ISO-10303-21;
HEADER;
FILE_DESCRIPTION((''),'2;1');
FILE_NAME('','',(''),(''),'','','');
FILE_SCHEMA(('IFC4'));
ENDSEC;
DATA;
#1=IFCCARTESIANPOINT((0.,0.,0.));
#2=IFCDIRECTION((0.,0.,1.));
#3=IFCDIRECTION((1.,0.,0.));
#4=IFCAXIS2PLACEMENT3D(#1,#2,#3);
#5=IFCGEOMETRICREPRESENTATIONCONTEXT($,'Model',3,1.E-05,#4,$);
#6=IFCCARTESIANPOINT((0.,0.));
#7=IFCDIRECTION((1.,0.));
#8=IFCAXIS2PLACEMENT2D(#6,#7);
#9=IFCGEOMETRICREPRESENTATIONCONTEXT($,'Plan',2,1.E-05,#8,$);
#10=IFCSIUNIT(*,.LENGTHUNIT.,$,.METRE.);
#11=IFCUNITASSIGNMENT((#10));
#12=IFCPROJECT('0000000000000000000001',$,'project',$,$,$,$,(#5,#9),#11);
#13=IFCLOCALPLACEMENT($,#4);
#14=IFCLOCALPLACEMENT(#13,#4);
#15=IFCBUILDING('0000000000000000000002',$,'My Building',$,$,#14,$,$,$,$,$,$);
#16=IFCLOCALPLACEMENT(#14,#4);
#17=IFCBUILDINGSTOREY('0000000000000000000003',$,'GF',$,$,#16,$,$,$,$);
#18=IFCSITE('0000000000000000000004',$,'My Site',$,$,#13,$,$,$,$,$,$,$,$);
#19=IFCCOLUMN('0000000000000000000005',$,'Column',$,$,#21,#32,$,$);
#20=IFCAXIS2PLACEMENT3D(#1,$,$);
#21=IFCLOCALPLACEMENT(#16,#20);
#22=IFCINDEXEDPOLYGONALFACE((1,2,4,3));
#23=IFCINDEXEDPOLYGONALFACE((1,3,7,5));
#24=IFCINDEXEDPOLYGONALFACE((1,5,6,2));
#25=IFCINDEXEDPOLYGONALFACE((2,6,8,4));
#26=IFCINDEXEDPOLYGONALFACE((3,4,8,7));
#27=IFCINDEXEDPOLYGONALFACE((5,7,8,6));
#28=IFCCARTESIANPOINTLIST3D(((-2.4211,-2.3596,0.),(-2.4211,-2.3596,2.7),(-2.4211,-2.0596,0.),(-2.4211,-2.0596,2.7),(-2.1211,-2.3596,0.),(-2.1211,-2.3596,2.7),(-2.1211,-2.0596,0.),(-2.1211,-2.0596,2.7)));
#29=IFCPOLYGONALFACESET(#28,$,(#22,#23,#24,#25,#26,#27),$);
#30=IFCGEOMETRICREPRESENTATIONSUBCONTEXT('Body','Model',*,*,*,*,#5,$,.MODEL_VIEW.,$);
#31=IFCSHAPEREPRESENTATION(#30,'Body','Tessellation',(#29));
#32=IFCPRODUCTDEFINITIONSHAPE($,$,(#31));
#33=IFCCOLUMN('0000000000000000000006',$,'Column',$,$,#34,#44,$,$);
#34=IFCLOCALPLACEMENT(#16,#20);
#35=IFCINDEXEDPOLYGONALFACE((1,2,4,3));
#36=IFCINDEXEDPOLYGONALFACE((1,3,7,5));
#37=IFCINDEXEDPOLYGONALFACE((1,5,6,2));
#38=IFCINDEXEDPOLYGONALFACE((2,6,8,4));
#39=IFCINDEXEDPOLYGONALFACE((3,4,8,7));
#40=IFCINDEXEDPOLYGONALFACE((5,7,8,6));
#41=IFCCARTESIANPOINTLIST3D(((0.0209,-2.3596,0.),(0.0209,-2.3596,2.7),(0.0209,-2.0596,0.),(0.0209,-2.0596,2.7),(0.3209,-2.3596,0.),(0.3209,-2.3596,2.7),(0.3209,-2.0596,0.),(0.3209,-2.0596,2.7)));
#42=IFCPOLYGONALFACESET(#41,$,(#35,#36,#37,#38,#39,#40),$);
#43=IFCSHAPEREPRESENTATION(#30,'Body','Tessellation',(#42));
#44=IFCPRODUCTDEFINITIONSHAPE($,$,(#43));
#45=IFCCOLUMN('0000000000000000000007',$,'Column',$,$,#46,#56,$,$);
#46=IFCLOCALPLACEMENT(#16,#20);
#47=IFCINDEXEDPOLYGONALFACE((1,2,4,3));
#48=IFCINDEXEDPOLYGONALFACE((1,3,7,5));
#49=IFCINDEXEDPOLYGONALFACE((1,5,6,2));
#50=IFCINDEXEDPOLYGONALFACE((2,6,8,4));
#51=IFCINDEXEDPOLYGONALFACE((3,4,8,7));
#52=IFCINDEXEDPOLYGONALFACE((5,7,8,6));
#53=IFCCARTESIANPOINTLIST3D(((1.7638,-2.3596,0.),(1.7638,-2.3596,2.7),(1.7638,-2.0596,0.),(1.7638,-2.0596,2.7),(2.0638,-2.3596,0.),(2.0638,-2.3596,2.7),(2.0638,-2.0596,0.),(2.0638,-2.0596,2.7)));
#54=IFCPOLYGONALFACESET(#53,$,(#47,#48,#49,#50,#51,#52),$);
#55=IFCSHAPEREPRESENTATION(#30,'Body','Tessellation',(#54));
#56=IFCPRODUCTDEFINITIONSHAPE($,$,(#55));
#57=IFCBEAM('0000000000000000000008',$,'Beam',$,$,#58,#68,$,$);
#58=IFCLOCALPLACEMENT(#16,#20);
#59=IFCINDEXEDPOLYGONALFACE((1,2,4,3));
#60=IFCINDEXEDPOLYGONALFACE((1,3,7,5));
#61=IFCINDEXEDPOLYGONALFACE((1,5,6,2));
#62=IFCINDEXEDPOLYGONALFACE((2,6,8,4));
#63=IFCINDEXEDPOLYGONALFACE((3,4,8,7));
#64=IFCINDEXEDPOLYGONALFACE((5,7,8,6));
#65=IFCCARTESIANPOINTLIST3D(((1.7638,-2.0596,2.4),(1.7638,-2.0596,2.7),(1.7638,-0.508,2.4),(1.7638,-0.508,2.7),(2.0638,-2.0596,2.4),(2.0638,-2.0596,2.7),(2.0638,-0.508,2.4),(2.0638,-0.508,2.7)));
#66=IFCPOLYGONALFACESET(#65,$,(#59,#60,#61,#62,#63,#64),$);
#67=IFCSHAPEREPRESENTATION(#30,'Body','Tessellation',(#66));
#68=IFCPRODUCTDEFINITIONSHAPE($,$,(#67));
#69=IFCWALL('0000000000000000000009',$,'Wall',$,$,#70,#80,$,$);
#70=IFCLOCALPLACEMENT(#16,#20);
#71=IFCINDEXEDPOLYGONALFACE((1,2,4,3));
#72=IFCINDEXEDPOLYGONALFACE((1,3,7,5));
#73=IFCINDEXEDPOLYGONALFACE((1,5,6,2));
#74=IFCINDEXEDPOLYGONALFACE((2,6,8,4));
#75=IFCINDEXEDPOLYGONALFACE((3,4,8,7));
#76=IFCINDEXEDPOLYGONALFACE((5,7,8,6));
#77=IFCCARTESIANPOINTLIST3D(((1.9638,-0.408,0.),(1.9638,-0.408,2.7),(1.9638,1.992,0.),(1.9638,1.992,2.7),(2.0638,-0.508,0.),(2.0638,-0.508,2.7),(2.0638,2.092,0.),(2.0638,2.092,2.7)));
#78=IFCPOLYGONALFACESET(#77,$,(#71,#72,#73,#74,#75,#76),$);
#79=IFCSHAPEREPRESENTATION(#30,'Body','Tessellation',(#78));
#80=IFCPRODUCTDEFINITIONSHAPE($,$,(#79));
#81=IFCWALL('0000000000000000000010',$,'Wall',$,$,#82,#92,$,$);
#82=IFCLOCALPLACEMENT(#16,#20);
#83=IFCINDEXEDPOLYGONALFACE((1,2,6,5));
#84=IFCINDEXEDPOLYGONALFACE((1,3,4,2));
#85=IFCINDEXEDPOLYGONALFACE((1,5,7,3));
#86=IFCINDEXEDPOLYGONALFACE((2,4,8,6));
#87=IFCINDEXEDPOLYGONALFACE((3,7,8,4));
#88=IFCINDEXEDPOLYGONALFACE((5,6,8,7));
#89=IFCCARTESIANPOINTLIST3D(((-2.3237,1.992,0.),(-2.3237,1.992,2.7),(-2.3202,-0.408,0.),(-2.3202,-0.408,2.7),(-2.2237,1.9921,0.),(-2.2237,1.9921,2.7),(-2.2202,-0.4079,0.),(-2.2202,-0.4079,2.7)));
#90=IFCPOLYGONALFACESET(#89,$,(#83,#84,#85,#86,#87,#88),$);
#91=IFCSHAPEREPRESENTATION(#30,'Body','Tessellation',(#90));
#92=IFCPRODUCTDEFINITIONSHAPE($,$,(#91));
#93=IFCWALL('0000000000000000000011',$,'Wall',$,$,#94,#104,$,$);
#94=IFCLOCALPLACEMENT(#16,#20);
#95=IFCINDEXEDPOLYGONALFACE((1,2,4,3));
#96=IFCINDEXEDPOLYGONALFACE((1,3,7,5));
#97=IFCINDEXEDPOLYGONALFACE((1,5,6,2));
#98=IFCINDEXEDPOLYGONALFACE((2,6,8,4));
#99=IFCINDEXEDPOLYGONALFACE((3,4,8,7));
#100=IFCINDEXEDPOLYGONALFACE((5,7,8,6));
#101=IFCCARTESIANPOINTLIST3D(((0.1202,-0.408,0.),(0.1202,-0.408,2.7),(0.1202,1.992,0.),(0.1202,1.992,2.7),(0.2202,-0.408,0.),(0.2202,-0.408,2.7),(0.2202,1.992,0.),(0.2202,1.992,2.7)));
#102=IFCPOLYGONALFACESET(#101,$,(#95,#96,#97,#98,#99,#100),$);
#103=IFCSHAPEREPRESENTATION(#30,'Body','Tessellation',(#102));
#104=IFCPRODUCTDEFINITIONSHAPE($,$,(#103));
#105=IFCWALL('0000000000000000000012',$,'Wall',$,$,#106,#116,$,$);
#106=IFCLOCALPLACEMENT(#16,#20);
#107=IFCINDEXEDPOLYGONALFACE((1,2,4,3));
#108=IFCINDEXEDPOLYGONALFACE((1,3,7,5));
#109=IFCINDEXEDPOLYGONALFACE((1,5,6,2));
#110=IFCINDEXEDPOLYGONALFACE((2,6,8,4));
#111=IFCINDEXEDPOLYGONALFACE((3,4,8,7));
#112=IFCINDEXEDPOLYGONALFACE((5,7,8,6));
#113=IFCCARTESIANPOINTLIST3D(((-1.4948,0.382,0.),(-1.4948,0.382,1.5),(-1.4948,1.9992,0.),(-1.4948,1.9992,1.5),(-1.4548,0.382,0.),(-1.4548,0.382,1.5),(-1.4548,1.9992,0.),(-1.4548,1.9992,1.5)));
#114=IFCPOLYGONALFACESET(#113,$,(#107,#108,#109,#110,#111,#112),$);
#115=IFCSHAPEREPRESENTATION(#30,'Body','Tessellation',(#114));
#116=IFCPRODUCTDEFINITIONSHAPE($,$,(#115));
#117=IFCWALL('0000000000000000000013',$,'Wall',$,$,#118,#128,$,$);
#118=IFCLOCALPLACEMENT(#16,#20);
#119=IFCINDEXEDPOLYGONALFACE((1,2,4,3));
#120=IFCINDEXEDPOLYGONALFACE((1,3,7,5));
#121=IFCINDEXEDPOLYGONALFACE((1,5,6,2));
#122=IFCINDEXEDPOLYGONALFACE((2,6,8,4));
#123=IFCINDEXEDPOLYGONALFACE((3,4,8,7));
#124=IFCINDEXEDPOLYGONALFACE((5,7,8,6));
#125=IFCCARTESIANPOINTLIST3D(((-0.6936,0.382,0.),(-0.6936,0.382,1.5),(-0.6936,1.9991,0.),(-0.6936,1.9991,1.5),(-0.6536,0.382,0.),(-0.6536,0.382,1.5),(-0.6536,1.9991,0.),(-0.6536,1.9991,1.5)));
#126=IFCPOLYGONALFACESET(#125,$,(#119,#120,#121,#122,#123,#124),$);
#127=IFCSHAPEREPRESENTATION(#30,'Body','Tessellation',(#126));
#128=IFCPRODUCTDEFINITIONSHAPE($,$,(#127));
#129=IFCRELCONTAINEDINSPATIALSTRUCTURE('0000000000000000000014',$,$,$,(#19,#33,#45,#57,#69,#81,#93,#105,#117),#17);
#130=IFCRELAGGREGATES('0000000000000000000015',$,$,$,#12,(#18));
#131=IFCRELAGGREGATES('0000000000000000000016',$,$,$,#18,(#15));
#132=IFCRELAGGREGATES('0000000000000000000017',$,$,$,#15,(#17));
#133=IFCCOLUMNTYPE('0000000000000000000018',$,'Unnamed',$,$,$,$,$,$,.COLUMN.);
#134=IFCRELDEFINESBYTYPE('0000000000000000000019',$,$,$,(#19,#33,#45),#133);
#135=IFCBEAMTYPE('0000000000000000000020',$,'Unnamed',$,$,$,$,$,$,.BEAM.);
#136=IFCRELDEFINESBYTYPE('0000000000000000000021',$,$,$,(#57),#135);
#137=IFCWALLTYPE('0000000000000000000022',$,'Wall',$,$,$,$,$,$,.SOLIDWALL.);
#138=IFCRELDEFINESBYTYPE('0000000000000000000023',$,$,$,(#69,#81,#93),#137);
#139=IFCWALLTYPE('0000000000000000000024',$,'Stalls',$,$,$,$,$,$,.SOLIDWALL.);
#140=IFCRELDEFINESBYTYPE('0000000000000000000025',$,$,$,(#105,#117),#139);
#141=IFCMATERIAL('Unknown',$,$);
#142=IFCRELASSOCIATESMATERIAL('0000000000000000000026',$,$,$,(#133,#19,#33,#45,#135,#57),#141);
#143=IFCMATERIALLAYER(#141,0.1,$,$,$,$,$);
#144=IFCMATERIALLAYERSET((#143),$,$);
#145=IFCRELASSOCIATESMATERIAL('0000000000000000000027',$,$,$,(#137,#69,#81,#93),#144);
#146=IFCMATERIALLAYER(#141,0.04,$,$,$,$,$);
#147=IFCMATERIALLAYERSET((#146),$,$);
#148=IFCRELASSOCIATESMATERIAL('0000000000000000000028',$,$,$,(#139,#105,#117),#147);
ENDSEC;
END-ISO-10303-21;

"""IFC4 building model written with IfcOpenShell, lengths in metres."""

from ifc_helpers import new_model, si_unit, frame, origin_with_axes, origin_2d_with_axis, place, context, subcontext, project, spatial, line, indexed_curve, rectangle, outline, extrude, material, layer, layer_set, layer_usage, material_profile, profile_set, profile_usage, type_object, element, save


model = new_model("IFC4")

# Units and contexts
model_context = context("Model", 3, precision=1e-05, world=origin_with_axes())
plan_context = context("Plan", 2, precision=1e-05, world=origin_2d_with_axis())
body_context_1 = subcontext(model_context, "Body", "Model", "MODEL_VIEW")
ifc_project = project(units=[si_unit("LENGTHUNIT", "METRE")], contexts=[model_context, plan_context])

# Site, building, storey
site_placement = place(None, origin_with_axes())
site = spatial("IfcSite", under=ifc_project, at=site_placement, Name="My Site")
building_placement = place(site_placement, origin_with_axes())
building = spatial("IfcBuilding", under=site, at=building_placement, Name="My Building")
storey_placement = place(building_placement, origin_with_axes())
storey = spatial("IfcBuildingStorey", under=building, at=storey_placement, Name="GF")

# Columns
ifc_material = material(Name="Unknown")
ifc_material_profile_1 = material_profile(ifc_material, rectangle(XDim=0.3, YDim=0.3))
ifc_profile_set_1 = profile_set([ifc_material_profile_1])
ifc_profile_usage_1 = profile_usage(ifc_profile_set_1, cardinal=5)
column_type = type_object("IfcColumnType", Name="Unnamed", PredefinedType="COLUMN", material=ifc_profile_set_1)
column_1_placement = place(storey_placement, frame((-2.2711, -2.2096, 0.0), z_axis=(0.0, 0.0, 1.0), x_axis=(1.0, 0.0, 0.0)))
element("IfcColumn", 1, at=column_1_placement, inside=storey, type_object=column_type, material=ifc_profile_usage_1, Name="Column", context=body_context_1, shape_type="SweptSolid", body=[
    extrude(rectangle(XDim=0.3, YDim=0.3), origin_with_axes(), (0.0, 0.0, 1.0), 2.7),
])
ifc_profile_usage_2 = profile_usage(ifc_profile_set_1, cardinal=5)
column_2_placement = place(storey_placement, frame((0.1709, -2.2096, 0.0), z_axis=(0.0, 0.0, 1.0), x_axis=(1.0, 0.0, 0.0)))
element("IfcColumn", 2, at=column_2_placement, inside=storey, type_object=column_type, material=ifc_profile_usage_2, Name="Column", context=body_context_1, shape_type="SweptSolid", body=[
    extrude(rectangle(XDim=0.3, YDim=0.3), origin_with_axes(), (0.0, 0.0, 1.0), 2.7),
])
ifc_profile_usage_3 = profile_usage(ifc_profile_set_1, cardinal=4)
column_3_placement = place(storey_placement, frame((2.0638, -2.2096, 0.0), z_axis=(0.0, 0.0, 1.0), x_axis=(1.0, 0.0, 0.0)))
element("IfcColumn", 3, at=column_3_placement, inside=storey, type_object=column_type, material=ifc_profile_usage_3, Name="Column", context=body_context_1, shape_type="SweptSolid", body=[
    extrude(rectangle(XDim=0.3, YDim=0.3), frame((-0.15, 0.0, 0.0), z_axis=(0.0, 0.0, 1.0), x_axis=(1.0, 0.0, 0.0)), (0.0, 0.0, 1.0), 2.7),
])

# Beam
ifc_material_profile_2 = material_profile(ifc_material, rectangle(XDim=0.3, YDim=0.3))
ifc_profile_set_2 = profile_set([ifc_material_profile_2])
ifc_profile_usage_4 = profile_usage(ifc_profile_set_2, cardinal=7)
beam_type = type_object("IfcBeamType", Name="Unnamed", PredefinedType="BEAM", material=ifc_profile_set_2)
beam_placement = place(storey_placement, frame((2.0638, -0.508, 2.7), z_axis=(0.0, -1.0, 0.0), x_axis=(1.0, 0.0, 0.0)))
element("IfcBeam", 4, at=beam_placement, inside=storey, type_object=beam_type, material=ifc_profile_usage_4, Name="Beam", context=body_context_1, shape_type="SweptSolid", body=[
    extrude(rectangle(XDim=0.3, YDim=0.3), frame((-0.15, -0.15, 0.0), z_axis=(0.0, 0.0, 1.0), x_axis=(1.0, 0.0, 0.0)), (0.0, 0.0, 1.0), 1.5515),
])

# Wall
ifc_layer_1 = layer(ifc_material, 0.1)
ifc_layer_set_1 = layer_set([ifc_layer_1])
ifc_layer_usage_1 = layer_usage(ifc_layer_set_1, "AXIS2", "POSITIVE", 0.0)
wall_type_1 = type_object("IfcWallType", Name="Wall", PredefinedType="SOLIDWALL", material=ifc_layer_set_1)
wall_1_placement = place(storey_placement, frame((2.0638, -0.508, 0.0), z_axis=(0.0, 0.0, 1.0), x_axis=(0.0, 1.0, 0.0)))
element("IfcWall", 5, at=wall_1_placement, inside=storey, type_object=wall_type_1, material=ifc_layer_usage_1, Name="Wall", context=body_context_1, shape_type="SweptSolid", body=[
    extrude(outline(indexed_curve([(0.0, 0.0), (0.1, 0.1), (2.5, 0.1), (2.6, 0.0)], segments=[line(1, 2, 3, 4, 1)])), origin_with_axes(), (0.0, 0.0, 1.0), 2.7),
])

# Walls
ifc_layer_usage_2 = layer_usage(ifc_layer_set_1, "AXIS2", "POSITIVE", 0.0)
wall_2_placement = place(storey_placement, frame((-2.3237, 1.992, 0.0), z_axis=(0.0, 0.0, 1.0), x_axis=(0.001482, -0.999999, 0.0)))
element("IfcWall", 6, at=wall_2_placement, inside=storey, type_object=wall_type_1, material=ifc_layer_usage_2, Name="Wall", context=body_context_1, shape_type="SweptSolid", body=[
    extrude(outline(indexed_curve([(0.0, 0.0), (0.0, 0.1), (2.4, 0.1), (2.4, 0.0)], segments=[line(1, 2, 3, 4, 1)])), origin_with_axes(), (0.0, 0.0, 1.0), 2.7),
])
ifc_layer_usage_3 = layer_usage(ifc_layer_set_1, "AXIS2", "POSITIVE", 0.0)
wall_3_placement = place(storey_placement, frame((0.1202, 1.992, 0.0), z_axis=(0.0, 0.0, 1.0), x_axis=(0.0, -1.0, 0.0)))
element("IfcWall", 7, at=wall_3_placement, inside=storey, type_object=wall_type_1, material=ifc_layer_usage_3, Name="Wall", context=body_context_1, shape_type="SweptSolid", body=[
    extrude(outline(indexed_curve([(0.0, 0.0), (0.0, 0.1), (2.3999, 0.1), (2.3999, 0.0)], segments=[line(1, 2, 3, 4, 1)])), origin_with_axes(), (0.0, 0.0, 1.0), 2.7),
])
ifc_layer_2 = layer(ifc_material, 0.04)
ifc_layer_set_2 = layer_set([ifc_layer_2])
ifc_layer_usage_4 = layer_usage(ifc_layer_set_2, "AXIS2", "POSITIVE", 0.0)
wall_type_2 = type_object("IfcWallType", Name="Stalls", PredefinedType="SOLIDWALL", material=ifc_layer_set_2)
wall_4_placement = place(storey_placement, frame((-1.4948, 1.9992, 0.0), z_axis=(0.0, 0.0, 1.0), x_axis=(0.0, -1.0, 0.0)))
element("IfcWall", 8, at=wall_4_placement, inside=storey, type_object=wall_type_2, material=ifc_layer_usage_4, Name="Wall", context=body_context_1, shape_type="SweptSolid", body=[
    extrude(outline(indexed_curve([(0.0, 0.0), (0.0, 0.04), (1.6172, 0.04), (1.6172, 0.0)], segments=[line(1, 2, 3, 4, 1)])), origin_with_axes(), (0.0, 0.0, 1.0), 1.5),
])
ifc_layer_usage_5 = layer_usage(ifc_layer_set_2, "AXIS2", "POSITIVE", 0.0)
wall_5_placement = place(storey_placement, frame((-0.6936, 1.9991, 0.0), z_axis=(0.0, 0.0, 1.0), x_axis=(0.0, -1.0, 0.0)))
element("IfcWall", 9, at=wall_5_placement, inside=storey, type_object=wall_type_2, material=ifc_layer_usage_5, Name="Wall", context=body_context_1, shape_type="SweptSolid", body=[
    extrude(outline(indexed_curve([(0.0, 0.0), (0.0, 0.04), (1.6172, 0.04), (1.6172, 0.0)], segments=[line(1, 2, 3, 4, 1)])), origin_with_axes(), (0.0, 0.0, 1.0), 1.5),
])

save(model, "model.ifc")
